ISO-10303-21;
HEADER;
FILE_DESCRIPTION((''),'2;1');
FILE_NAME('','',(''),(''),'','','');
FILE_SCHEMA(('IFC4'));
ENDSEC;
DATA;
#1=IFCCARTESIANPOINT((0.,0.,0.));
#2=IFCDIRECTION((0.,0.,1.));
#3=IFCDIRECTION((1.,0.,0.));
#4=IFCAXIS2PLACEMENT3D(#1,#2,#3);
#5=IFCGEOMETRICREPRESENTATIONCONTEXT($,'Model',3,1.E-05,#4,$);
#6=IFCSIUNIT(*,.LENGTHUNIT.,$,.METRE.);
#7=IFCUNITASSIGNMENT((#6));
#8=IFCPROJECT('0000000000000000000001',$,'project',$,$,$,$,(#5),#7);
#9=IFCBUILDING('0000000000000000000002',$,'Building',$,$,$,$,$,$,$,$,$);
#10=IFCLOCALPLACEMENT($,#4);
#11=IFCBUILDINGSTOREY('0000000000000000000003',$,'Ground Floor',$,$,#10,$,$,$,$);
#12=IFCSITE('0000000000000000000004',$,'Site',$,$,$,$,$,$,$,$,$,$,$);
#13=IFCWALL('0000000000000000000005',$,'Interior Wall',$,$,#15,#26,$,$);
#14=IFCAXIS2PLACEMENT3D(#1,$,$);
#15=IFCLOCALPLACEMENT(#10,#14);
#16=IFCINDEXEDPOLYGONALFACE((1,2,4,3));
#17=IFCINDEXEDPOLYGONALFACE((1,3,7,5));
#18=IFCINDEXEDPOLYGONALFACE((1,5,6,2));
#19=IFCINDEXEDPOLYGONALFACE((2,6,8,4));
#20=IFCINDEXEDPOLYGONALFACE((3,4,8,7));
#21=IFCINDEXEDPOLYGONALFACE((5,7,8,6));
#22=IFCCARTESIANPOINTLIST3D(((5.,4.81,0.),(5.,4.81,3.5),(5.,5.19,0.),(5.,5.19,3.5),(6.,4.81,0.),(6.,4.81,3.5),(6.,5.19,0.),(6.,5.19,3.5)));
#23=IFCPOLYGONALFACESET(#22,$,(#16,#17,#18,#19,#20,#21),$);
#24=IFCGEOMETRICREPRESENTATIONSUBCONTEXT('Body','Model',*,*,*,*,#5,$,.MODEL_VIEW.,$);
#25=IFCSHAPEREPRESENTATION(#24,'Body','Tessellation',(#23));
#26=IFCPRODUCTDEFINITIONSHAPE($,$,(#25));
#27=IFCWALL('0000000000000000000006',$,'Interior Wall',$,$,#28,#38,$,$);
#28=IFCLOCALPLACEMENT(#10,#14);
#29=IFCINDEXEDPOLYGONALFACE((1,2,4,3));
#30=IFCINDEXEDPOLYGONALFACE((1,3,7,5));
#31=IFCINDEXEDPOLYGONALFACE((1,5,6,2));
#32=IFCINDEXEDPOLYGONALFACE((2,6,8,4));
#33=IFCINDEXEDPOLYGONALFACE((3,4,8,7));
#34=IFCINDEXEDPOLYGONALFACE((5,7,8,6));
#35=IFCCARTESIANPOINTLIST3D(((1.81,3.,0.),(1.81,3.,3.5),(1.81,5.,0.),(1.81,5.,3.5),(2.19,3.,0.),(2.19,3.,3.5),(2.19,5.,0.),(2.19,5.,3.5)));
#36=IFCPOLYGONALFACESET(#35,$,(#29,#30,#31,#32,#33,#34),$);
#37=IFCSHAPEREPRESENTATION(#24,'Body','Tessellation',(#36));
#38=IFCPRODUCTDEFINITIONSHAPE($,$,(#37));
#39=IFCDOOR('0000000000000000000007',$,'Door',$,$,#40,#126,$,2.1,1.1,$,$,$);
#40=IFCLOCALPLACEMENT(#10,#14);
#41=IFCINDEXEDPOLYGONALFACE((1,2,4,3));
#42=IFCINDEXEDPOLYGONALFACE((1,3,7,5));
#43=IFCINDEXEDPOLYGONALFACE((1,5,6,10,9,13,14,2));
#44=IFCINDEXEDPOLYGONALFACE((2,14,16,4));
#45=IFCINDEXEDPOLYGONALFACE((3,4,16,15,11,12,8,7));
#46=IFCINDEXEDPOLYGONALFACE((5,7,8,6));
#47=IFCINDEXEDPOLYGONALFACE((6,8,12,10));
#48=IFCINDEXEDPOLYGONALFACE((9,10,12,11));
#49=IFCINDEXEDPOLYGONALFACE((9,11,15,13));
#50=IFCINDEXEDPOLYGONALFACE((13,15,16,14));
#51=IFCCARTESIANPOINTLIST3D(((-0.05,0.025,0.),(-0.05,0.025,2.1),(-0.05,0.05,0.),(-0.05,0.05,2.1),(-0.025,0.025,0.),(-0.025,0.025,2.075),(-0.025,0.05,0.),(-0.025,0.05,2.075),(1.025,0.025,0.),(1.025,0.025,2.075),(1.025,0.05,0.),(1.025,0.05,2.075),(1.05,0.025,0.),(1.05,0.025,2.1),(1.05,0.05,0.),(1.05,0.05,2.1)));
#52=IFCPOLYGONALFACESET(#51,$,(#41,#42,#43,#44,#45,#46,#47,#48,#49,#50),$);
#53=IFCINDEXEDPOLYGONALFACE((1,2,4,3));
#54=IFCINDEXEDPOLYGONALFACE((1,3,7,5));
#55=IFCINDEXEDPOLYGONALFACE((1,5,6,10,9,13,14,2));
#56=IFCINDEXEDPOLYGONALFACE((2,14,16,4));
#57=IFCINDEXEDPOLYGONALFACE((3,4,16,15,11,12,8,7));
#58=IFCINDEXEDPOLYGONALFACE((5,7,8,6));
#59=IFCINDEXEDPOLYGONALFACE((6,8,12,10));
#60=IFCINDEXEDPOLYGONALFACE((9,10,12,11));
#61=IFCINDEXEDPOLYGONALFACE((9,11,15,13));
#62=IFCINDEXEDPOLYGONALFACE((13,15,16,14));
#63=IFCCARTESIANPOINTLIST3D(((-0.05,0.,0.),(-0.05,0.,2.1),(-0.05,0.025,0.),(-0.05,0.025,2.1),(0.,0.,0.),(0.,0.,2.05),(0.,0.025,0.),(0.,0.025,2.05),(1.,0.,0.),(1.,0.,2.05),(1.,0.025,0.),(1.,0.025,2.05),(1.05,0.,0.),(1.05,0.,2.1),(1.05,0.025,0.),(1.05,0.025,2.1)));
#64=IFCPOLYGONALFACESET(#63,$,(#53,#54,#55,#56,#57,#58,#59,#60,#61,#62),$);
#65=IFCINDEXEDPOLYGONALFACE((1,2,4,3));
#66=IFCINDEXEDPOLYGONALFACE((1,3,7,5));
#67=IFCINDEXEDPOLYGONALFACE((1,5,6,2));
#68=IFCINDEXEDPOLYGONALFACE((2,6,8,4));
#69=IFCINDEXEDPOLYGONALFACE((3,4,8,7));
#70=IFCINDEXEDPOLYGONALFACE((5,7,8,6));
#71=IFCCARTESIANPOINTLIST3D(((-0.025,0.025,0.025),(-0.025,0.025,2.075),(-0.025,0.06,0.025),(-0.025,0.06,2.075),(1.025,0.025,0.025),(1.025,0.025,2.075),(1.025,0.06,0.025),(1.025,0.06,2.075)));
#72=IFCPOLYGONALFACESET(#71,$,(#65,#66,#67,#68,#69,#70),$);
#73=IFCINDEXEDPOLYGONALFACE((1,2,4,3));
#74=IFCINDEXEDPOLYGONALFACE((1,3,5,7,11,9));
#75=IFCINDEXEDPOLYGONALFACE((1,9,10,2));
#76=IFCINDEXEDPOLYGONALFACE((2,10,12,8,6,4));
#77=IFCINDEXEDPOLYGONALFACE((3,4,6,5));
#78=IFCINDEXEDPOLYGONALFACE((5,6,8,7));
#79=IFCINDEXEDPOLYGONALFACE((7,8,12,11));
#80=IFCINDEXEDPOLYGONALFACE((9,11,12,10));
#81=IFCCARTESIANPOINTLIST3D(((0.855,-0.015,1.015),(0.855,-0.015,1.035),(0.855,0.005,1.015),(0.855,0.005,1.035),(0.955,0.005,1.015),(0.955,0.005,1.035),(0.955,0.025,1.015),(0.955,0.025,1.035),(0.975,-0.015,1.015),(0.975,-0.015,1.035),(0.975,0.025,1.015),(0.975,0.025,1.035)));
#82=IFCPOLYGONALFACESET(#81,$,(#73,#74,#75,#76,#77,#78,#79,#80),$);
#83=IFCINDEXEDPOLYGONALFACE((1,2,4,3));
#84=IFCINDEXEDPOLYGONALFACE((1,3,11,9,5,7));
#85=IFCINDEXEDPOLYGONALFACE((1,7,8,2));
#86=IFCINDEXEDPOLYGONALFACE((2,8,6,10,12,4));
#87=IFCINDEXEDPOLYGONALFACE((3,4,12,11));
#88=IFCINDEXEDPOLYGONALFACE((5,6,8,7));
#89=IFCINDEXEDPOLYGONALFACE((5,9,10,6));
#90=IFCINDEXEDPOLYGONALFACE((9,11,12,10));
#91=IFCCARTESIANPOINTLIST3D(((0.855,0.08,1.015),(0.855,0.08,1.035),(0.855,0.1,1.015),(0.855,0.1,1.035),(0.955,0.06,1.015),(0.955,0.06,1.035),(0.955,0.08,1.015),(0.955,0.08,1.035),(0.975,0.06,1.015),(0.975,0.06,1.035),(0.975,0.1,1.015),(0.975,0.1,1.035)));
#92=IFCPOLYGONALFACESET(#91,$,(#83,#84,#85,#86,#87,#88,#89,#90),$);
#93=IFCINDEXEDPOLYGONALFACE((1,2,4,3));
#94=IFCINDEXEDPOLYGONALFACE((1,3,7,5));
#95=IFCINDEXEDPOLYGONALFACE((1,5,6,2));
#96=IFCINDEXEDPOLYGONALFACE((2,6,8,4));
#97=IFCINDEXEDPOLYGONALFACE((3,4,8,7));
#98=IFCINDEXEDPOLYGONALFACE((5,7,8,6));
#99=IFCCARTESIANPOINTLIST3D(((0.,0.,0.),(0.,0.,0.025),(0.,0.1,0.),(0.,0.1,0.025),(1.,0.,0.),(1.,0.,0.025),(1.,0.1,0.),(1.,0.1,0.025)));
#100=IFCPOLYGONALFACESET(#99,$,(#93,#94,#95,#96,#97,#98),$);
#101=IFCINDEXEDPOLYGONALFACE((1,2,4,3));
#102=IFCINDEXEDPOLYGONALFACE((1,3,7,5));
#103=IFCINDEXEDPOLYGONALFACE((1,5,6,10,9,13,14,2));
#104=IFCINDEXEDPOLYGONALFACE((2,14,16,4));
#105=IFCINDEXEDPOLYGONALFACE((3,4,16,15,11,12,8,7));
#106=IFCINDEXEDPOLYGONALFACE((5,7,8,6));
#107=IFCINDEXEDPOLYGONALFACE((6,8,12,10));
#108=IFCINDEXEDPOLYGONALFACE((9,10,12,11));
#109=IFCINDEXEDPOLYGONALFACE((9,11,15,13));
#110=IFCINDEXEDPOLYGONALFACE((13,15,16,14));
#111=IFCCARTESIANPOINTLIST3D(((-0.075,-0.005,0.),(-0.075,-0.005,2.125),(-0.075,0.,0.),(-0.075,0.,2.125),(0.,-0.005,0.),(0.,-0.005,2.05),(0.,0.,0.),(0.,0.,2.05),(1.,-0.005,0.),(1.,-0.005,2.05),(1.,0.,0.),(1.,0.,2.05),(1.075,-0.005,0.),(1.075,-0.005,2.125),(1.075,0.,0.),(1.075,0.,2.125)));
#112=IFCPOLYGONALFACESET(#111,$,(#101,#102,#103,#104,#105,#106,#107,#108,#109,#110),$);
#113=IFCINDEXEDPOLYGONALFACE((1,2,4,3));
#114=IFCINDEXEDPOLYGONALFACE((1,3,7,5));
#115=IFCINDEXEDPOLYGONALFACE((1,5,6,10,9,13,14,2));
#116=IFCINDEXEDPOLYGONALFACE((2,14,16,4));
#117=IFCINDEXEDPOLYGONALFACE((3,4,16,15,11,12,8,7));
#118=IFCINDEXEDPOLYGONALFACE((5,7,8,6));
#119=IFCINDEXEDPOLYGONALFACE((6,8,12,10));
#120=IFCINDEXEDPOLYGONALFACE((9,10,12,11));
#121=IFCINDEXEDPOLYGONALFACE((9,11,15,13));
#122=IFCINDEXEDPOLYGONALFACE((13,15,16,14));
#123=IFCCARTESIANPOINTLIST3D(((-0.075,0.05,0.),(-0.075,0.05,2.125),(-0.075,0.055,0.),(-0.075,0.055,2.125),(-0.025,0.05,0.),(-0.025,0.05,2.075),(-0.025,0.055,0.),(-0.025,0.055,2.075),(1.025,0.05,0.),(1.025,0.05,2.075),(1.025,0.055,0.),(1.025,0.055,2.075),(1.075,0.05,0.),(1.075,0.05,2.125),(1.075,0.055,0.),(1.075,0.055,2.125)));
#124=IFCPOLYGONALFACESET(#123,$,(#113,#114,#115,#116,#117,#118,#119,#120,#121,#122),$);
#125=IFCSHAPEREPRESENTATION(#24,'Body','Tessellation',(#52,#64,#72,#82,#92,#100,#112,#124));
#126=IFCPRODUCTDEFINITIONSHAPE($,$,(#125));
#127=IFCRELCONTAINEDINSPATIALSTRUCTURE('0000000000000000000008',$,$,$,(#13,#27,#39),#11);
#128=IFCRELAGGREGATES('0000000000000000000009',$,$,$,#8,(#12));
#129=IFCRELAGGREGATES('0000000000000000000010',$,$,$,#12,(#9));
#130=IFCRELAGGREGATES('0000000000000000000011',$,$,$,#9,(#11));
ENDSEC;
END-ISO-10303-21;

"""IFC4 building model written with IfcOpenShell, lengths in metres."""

from ifc_helpers import new_model, si_unit, frame, origin_with_axes, place, context, subcontext, project, spatial, line, indexed_curve, outline, extrude, element, save


model = new_model("IFC4")

# Units and contexts
model_context = context("Model", 3, precision=1e-05, world=origin_with_axes())
body_context = subcontext(model_context, "Body", "Model", "MODEL_VIEW")
ifc_project = project(units=[si_unit("LENGTHUNIT", "METRE")], contexts=[model_context])

# Site, building, storey
site = spatial("IfcSite", under=ifc_project, Name="Site")
building = spatial("IfcBuilding", under=site, Name="Building")
storey_placement = place(None, origin_with_axes())
storey = spatial("IfcBuildingStorey", under=building, at=storey_placement, Name="Ground Floor")

# Walls
wall_1_placement = place(storey_placement, frame((6.0, 5.0, 0.0), z_axis=(0.0, 0.0, 1.0), x_axis=(-1.0, 0.0, 0.0)))
element("IfcWall", 1, at=wall_1_placement, inside=storey, Name="Interior Wall", context=body_context, shape_type="SweptSolid", body=[
    extrude(outline(indexed_curve([(0.0, 0.0), (0.0, 0.38), (1.0, 0.38), (1.0, 0.0), (0.0, 0.0)], self_intersect=False)), frame((0.0, -0.19, 0.0), z_axis=(0.0, 0.0, 1.0), x_axis=(1.0, 0.0, 0.0)), (0.0, 0.0, 1.0), 3.5),
])
wall_2_placement = place(storey_placement, frame((2.0, 5.0, 0.0), z_axis=(0.0, 0.0, 1.0), x_axis=(0.0, -1.0, 0.0)))
element("IfcWall", 2, at=wall_2_placement, inside=storey, Name="Interior Wall", context=body_context, shape_type="SweptSolid", body=[
    extrude(outline(indexed_curve([(0.0, 0.0), (0.0, 0.38), (2.0, 0.38), (2.0, 0.0), (0.0, 0.0)], self_intersect=False)), frame((0.0, -0.19, 0.0), z_axis=(0.0, 0.0, 1.0), x_axis=(1.0, 0.0, 0.0)), (0.0, 0.0, 1.0), 3.5),
])

# Door
door_1_placement = place(storey_placement, frame((-0.05, 0.0, 0.0), z_axis=(0.0, 0.0, 1.0), x_axis=(1.0, 0.0, 0.0)))
element("IfcDoor", 3, at=door_1_placement, inside=storey, Name="Door", OverallHeight=2.1, OverallWidth=1.1, context=body_context, shape_type="SweptSolid", body=[
    extrude(outline(indexed_curve([(0.0, 0.0), (0.0, 2.1), (1.1, 2.1), (1.1, 0.0), (1.075, 0.0), (1.075, 2.075), (0.025, 2.075), (0.025, 0.0)], segments=[line(1, 2, 3, 4, 5, 6, 7, 8, 1)])), frame((0.0, 0.025, 0.0), z_axis=(0.0, -1.0, 0.0), x_axis=(1.0, 0.0, 0.0)), (0.0, 0.0, -1.0), 0.025),
    extrude(outline(indexed_curve([(0.0, 0.0), (0.0, 2.1), (1.1, 2.1), (1.1, 0.0), (1.05, 0.0), (1.05, 2.05), (0.05, 2.05), (0.05, 0.0)], segments=[line(1, 2, 3, 4, 5, 6, 7, 8, 1)])), frame((0.0, 0.0, 0.0), z_axis=(0.0, -1.0, 0.0), x_axis=(1.0, 0.0, 0.0)), (0.0, 0.0, -1.0), 0.025),
    extrude(outline(indexed_curve([(0.0, 0.0), (1.05, 0.0), (1.05, 0.035), (0.0, 0.035)], segments=[line(1, 2, 3, 4, 1)])), frame((0.025, 0.025, 0.025), z_axis=(0.0, 0.0, 1.0), x_axis=(1.0, 0.0, 0.0)), (0.0, 0.0, 1.0), 2.05),
    extrude(outline(indexed_curve([(0.0, 0.0), (0.0, -0.04), (-0.12, -0.04), (-0.12, -0.02), (-0.02, -0.02), (-0.02, 0.0)], segments=[line(1, 2, 3, 4, 5, 6, 1)])), frame((1.025, 0.025, 1.015), z_axis=(0.0, 0.0, 1.0), x_axis=(1.0, 0.0, 0.0)), (0.0, 0.0, 1.0), 0.02),
    extrude(outline(indexed_curve([(0.0, 0.0), (0.0, 0.04), (-0.12, 0.04), (-0.12, 0.02), (-0.02, 0.02), (-0.02, 0.0)], segments=[line(1, 2, 3, 4, 5, 6, 1)])), frame((1.025, 0.06, 1.015), z_axis=(0.0, 0.0, 1.0), x_axis=(1.0, 0.0, 0.0)), (0.0, 0.0, 1.0), 0.02),
    extrude(outline(indexed_curve([(0.0, 0.0), (1.0, 0.0), (1.0, 0.1), (0.0, 0.1)], segments=[line(1, 2, 3, 4, 1)])), frame((0.05, 0.0, 0.0), z_axis=(0.0, 0.0, 1.0), x_axis=(1.0, 0.0, 0.0)), (0.0, 0.0, 1.0), 0.025),
    extrude(outline(indexed_curve([(0.0, 0.0), (0.0, 2.125), (1.15, 2.125), (1.15, 0.0), (1.075, 0.0), (1.075, 2.05), (0.075, 2.05), (0.075, 0.0)], segments=[line(1, 2, 3, 4, 5, 6, 7, 8, 1)])), frame((-0.025, -0.005, 0.0), z_axis=(0.0, -1.0, 0.0), x_axis=(1.0, 0.0, 0.0)), (0.0, 0.0, -1.0), 0.005),
    extrude(outline(indexed_curve([(0.0, 0.0), (0.0, 2.125), (1.15, 2.125), (1.15, 0.0), (1.1, 0.0), (1.1, 2.075), (0.05, 2.075), (0.05, 0.0)], segments=[line(1, 2, 3, 4, 5, 6, 7, 8, 1)])), frame((-0.025, 0.05, 0.0), z_axis=(0.0, -1.0, 0.0), x_axis=(1.0, 0.0, 0.0)), (0.0, 0.0, -1.0), 0.005),
])

save(model, "model.ifc")
